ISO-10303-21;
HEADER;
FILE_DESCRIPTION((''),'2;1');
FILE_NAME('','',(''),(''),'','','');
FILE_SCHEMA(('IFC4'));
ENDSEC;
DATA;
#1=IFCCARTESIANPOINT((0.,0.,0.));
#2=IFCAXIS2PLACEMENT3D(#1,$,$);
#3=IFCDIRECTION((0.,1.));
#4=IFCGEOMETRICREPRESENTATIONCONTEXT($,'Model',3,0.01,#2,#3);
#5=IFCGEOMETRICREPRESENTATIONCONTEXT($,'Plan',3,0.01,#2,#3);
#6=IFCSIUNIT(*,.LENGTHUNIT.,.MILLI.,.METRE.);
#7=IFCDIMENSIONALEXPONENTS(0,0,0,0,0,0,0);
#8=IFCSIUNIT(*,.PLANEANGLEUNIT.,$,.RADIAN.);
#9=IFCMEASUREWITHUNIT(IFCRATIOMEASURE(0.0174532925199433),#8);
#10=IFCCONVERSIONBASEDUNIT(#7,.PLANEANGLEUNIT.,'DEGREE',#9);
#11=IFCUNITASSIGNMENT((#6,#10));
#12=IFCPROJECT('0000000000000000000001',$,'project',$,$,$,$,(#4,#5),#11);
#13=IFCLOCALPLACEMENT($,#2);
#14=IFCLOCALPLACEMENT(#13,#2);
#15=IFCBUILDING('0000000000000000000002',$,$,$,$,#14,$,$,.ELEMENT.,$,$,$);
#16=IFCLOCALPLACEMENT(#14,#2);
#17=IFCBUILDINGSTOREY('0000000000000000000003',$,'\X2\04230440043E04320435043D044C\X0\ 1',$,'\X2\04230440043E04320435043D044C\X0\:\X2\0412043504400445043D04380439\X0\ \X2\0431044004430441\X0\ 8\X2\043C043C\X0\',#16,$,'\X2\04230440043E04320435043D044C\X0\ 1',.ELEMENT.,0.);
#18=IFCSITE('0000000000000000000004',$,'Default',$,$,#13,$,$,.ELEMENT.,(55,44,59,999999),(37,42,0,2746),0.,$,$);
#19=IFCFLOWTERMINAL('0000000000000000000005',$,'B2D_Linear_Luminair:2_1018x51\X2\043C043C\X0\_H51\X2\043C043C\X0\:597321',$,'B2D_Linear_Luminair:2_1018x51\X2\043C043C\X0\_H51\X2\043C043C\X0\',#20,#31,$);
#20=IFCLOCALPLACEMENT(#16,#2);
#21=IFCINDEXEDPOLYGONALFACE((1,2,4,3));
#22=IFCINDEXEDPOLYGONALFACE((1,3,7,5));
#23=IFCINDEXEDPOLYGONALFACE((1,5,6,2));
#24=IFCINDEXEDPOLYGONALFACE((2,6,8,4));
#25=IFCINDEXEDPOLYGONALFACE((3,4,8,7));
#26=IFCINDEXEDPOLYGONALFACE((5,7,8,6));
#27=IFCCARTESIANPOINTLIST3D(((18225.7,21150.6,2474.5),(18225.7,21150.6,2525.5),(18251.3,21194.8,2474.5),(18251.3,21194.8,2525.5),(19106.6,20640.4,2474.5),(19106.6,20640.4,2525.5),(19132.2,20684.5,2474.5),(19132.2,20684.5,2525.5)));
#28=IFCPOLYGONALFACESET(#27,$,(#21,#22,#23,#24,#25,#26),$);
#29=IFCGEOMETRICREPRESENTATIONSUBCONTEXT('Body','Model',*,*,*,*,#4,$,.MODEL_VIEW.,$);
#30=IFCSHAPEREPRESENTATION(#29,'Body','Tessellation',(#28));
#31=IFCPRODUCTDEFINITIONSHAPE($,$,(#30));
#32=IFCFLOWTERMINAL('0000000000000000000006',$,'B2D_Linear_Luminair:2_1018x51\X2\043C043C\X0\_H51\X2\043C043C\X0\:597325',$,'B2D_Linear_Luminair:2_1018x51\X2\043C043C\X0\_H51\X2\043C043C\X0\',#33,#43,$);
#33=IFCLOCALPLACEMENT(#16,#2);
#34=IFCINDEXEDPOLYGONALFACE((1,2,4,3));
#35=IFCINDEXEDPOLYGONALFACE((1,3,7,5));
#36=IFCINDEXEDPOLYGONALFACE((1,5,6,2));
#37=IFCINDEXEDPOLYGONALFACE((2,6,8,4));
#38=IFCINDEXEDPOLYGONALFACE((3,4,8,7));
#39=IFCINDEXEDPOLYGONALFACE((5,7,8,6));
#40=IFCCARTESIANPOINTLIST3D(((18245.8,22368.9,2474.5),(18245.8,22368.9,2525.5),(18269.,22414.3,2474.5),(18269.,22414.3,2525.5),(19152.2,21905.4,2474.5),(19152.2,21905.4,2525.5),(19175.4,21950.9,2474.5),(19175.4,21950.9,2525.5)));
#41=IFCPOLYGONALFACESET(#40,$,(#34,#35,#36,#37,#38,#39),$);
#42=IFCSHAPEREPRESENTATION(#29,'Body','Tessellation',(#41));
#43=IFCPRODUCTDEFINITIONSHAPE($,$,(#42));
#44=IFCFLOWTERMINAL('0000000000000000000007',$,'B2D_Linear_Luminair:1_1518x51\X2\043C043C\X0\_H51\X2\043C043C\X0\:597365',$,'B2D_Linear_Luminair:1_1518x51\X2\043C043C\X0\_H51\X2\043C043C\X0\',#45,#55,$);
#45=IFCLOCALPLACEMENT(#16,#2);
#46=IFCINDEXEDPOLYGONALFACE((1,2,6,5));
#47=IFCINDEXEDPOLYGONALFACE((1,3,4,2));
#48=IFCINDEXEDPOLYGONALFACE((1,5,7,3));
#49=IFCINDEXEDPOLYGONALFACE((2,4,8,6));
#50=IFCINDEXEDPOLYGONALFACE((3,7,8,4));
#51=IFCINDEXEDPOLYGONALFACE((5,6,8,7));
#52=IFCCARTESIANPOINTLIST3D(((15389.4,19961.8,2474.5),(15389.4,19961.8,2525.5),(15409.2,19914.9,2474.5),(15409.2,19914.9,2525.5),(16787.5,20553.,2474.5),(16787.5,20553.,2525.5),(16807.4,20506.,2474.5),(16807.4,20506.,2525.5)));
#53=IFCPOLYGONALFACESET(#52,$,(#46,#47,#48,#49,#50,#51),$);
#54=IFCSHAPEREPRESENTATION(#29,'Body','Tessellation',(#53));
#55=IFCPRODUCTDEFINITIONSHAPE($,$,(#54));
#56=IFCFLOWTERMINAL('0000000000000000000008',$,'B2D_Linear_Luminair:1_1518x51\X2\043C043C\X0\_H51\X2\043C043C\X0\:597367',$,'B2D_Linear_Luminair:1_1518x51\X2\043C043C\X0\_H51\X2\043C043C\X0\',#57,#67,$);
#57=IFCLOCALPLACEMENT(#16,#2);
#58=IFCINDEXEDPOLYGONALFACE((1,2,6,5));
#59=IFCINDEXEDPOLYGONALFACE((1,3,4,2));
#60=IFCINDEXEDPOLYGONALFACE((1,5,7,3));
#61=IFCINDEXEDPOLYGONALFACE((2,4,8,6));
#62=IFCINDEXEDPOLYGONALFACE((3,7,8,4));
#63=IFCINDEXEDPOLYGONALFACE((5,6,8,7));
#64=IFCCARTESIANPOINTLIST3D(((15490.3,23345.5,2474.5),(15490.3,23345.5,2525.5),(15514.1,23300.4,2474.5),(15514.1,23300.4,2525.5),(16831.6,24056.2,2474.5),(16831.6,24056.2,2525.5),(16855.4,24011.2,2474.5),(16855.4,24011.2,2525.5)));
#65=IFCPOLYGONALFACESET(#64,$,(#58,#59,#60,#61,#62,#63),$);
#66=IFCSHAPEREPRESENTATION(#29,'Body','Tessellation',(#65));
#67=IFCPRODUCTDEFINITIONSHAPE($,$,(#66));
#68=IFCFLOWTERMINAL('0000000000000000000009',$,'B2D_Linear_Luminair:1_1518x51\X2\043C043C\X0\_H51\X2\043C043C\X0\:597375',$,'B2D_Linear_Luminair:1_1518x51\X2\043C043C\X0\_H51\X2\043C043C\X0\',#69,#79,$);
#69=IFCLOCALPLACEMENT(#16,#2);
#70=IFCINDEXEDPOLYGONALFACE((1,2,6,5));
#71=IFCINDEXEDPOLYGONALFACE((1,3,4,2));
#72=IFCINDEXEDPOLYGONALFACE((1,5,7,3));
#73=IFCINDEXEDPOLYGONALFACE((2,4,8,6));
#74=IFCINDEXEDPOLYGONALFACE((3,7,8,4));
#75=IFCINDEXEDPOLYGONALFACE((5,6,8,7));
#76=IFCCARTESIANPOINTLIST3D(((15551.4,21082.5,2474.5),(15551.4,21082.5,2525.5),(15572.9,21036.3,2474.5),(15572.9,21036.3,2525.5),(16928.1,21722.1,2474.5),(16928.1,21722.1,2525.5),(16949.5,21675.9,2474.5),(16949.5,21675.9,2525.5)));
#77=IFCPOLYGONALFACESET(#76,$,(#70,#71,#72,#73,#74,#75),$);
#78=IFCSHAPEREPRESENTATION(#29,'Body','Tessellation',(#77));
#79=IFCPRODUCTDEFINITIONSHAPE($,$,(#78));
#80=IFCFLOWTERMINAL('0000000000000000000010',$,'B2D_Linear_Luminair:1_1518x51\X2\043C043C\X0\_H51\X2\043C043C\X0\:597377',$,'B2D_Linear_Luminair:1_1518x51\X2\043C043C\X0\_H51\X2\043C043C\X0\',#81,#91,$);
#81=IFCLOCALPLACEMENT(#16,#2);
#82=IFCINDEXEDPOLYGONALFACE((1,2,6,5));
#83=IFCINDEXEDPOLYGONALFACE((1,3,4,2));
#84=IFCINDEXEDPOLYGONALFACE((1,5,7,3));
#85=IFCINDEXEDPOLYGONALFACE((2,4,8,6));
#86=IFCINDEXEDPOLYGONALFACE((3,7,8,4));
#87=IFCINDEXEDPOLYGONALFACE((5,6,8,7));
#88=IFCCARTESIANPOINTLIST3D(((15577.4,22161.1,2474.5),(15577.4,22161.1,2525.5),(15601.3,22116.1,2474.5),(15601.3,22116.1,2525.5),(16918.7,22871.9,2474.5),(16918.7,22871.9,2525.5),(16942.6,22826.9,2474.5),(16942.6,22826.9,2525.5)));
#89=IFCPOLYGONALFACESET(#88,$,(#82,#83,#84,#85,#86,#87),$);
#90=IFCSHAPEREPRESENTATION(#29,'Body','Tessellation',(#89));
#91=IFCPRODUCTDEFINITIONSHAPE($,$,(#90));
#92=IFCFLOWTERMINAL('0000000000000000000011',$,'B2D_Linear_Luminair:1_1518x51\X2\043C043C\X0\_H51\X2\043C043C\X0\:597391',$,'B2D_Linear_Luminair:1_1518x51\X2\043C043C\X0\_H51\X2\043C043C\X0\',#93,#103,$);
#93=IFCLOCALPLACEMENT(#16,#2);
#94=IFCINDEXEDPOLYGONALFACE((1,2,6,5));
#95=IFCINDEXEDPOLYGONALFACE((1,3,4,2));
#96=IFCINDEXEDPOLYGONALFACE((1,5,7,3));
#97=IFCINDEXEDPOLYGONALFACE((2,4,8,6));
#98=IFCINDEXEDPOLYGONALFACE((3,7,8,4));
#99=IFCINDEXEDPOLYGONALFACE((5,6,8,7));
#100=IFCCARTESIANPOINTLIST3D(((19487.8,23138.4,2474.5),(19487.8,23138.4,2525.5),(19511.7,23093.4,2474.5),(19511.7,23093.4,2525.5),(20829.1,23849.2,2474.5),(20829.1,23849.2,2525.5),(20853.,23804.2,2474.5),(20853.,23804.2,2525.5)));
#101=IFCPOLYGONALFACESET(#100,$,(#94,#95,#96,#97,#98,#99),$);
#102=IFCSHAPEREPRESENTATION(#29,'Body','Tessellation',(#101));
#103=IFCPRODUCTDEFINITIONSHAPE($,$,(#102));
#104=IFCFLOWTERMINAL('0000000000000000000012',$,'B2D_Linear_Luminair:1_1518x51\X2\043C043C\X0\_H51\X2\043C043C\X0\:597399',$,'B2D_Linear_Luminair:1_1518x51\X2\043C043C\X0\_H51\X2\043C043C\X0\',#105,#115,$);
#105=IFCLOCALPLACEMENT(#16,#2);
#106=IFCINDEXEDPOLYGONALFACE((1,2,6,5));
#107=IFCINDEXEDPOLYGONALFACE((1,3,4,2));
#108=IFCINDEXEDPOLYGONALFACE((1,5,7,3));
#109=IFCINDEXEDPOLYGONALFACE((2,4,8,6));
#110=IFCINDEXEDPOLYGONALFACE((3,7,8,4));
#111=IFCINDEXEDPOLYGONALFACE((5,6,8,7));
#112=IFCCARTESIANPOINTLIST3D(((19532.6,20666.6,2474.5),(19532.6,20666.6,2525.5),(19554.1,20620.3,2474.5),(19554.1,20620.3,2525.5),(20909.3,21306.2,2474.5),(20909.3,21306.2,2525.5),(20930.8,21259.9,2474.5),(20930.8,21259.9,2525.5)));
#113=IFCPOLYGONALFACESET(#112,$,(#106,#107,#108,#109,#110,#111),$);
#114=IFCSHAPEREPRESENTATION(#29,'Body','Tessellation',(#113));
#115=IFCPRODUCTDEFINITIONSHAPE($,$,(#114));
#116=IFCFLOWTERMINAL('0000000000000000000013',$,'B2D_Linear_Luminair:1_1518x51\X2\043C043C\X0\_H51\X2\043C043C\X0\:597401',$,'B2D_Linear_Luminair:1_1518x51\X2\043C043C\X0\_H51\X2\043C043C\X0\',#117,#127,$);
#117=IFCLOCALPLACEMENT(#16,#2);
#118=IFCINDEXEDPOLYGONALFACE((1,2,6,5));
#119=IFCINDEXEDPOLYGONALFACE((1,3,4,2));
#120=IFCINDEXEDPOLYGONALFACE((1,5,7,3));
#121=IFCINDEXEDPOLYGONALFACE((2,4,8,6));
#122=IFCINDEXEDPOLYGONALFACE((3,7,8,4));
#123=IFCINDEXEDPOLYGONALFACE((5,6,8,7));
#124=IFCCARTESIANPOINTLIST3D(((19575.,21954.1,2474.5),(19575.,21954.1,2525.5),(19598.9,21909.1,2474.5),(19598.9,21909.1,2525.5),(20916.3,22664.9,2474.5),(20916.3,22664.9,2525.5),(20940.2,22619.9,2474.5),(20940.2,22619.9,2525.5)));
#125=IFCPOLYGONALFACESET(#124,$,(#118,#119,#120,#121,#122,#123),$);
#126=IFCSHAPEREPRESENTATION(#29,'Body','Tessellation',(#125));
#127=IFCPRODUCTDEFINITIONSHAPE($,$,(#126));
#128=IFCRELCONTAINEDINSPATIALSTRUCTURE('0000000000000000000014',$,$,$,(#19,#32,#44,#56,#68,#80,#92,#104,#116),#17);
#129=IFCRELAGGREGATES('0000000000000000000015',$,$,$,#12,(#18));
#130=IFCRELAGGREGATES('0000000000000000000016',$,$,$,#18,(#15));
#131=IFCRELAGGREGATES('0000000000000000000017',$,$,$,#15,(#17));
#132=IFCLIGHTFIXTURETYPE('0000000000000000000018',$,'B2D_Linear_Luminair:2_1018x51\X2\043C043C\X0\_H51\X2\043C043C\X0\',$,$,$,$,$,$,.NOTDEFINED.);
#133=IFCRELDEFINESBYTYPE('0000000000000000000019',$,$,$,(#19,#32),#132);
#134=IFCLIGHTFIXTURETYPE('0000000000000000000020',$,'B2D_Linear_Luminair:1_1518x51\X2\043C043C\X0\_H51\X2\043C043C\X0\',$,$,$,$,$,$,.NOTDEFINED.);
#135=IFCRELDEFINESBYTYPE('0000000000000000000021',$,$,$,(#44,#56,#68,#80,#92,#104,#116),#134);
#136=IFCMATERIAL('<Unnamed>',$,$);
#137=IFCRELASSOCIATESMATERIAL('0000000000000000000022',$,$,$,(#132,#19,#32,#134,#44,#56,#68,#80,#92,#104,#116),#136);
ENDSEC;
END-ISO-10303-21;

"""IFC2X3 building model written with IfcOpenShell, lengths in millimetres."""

from ifc_helpers import new_model, entity, si_unit, converted_unit, direction, frame, origin, origin_2d_with_axis, place, context, subcontext, project, spatial, rectangle, extrude, source, transform, mapped, material, type_object, type_shapes, element, save


model = new_model("IFC2X3")

# Units and contexts
model_context = context("Model", 3, precision=0.01, world=origin(), true_north=direction((0.0, 1.0)))
plan_context = context("Plan", 3, precision=0.01, world=origin(), true_north=direction((0.0, 1.0)))
body_context = subcontext(model_context, "Body", "Model", "MODEL_VIEW")
ifc_project = project(units=[si_unit("LENGTHUNIT", "METRE", prefix="MILLI"), converted_unit("PLANEANGLEUNIT", "DEGREE", entity("IfcRatioMeasure", 0.0174532925199433), si_unit("PLANEANGLEUNIT", "RADIAN"), dimensions=[0, 0, 0, 0, 0, 0, 0])], contexts=[model_context, plan_context])

# Site, building, storey
site_placement = place(None, origin())
site = spatial("IfcSite", under=ifc_project, at=site_placement, Name="Default", CompositionType="ELEMENT", RefLatitude=(55, 44, 59, 999999), RefLongitude=(37, 42, 0, 2746), RefElevation=0.0)
building_placement = place(site_placement, origin())
building = spatial("IfcBuilding", under=site, at=building_placement, CompositionType="ELEMENT")
storey_placement = place(building_placement, origin())
storey = spatial("IfcBuildingStorey", under=building, at=storey_placement, Name="Уровень 1", ObjectType="Уровень:Верхний брус 8мм", LongName="Уровень 1", CompositionType="ELEMENT", Elevation=0.0)

# Flow terminals
ifc_material = material(Name="<Unnamed>")
light_fixture_type_1 = type_object("IfcLightFixtureType", Name="B2D_Linear_Luminair:2_1018x51мм_H51мм", PredefinedType="NOTDEFINED", material=ifc_material)
shared_shape_1 = source(origin(), body_context, "Body", "SweptSolid", [
    extrude(rectangle(XDim=1018.0, YDim=51.0, at=origin_2d_with_axis()), frame((0.0, 0.0, 0.0), z_axis=(0.0, 0.0, 1.0), x_axis=(-1.0, 0.0, 0.0)), (0.0, 0.0, 1.0), 51.0),
])
type_shapes(light_fixture_type_1, [shared_shape_1])
for number, where, z_axis, x_axis, name in (
    (1, (18679.0, 20917.6, 2525.5), (0.0, 0.0, -1.0), (0.865326, -0.501209, 0.0), "B2D_Linear_Luminair:2_1018x51мм_H51мм:597321"),
    (2, (18710.6, 22159.9, 2525.5), (0.0, 0.0, -1.0), (0.890372, -0.455234, 0.0), "B2D_Linear_Luminair:2_1018x51мм_H51мм:597325"),
):
    element("IfcFlowTerminal", number, at=place(storey_placement, frame(where, z_axis=z_axis, x_axis=x_axis)), inside=storey, type_object=light_fixture_type_1, material=ifc_material, Name=name, ObjectType="B2D_Linear_Luminair:2_1018x51мм_H51мм", context=body_context, shape_type="MappedRepresentation", body=[
        mapped(shared_shape_1, transform((0.0, 0.0, 0.0), scale=1.0)),
    ])
light_fixture_type_2 = type_object("IfcLightFixtureType", Name="B2D_Linear_Luminair:1_1518x51мм_H51мм", PredefinedType="NOTDEFINED", material=ifc_material)
shared_shape_2 = source(origin(), body_context, "Body", "SweptSolid", [
    extrude(rectangle(XDim=1518.0, YDim=51.0, at=origin_2d_with_axis()), frame((0.0, 0.0, 0.0), z_axis=(0.0, 0.0, 1.0), x_axis=(-1.0, 0.0, 0.0)), (0.0, 0.0, 1.0), 51.0),
])
type_shapes(light_fixture_type_2, [shared_shape_2])
for number, where, z_axis, x_axis, name in (
    (3, (16098.4, 20233.9, 2525.5), (0.0, 0.0, -1.0), (0.92105, 0.389445, 0.0), "B2D_Linear_Luminair:1_1518x51мм_H51мм:597365"),
    (4, (16172.9, 23678.3, 2525.5), (0.0, 0.0, -1.0), (0.883602, 0.468238, 0.0), "B2D_Linear_Luminair:1_1518x51мм_H51мм:597367"),
    (5, (16250.5, 21379.2, 2525.5), (0.0, 0.0, -1.0), (0.906897, 0.421352, 0.0), "B2D_Linear_Luminair:1_1518x51мм_H51мм:597375"),
    (6, (16260.0, 22494.0, 2525.5), (0.0, 0.0, -1.0), (0.883602, 0.468238, 0.0), "B2D_Linear_Luminair:1_1518x51мм_H51мм:597377"),
    (7, (20170.4, 23471.3, 2525.5), (0.0, 0.0, -1.0), (0.883602, 0.468238, 0.0), "B2D_Linear_Luminair:1_1518x51мм_H51мм:597391"),
    (8, (20231.7, 20963.2, 2525.5), (0.0, 0.0, -1.0), (0.906897, 0.421352, 0.0), "B2D_Linear_Luminair:1_1518x51мм_H51мм:597399"),
    (9, (20257.6, 22287.0, 2525.5), (0.0, 0.0, -1.0), (0.883602, 0.468238, 0.0), "B2D_Linear_Luminair:1_1518x51мм_H51мм:597401"),
):
    element("IfcFlowTerminal", number, at=place(storey_placement, frame(where, z_axis=z_axis, x_axis=x_axis)), inside=storey, type_object=light_fixture_type_2, material=ifc_material, Name=name, ObjectType="B2D_Linear_Luminair:1_1518x51мм_H51мм", context=body_context, shape_type="MappedRepresentation", body=[
        mapped(shared_shape_2, transform((0.0, 0.0, 0.0), scale=1.0)),
    ])

save(model, "model.ifc")
